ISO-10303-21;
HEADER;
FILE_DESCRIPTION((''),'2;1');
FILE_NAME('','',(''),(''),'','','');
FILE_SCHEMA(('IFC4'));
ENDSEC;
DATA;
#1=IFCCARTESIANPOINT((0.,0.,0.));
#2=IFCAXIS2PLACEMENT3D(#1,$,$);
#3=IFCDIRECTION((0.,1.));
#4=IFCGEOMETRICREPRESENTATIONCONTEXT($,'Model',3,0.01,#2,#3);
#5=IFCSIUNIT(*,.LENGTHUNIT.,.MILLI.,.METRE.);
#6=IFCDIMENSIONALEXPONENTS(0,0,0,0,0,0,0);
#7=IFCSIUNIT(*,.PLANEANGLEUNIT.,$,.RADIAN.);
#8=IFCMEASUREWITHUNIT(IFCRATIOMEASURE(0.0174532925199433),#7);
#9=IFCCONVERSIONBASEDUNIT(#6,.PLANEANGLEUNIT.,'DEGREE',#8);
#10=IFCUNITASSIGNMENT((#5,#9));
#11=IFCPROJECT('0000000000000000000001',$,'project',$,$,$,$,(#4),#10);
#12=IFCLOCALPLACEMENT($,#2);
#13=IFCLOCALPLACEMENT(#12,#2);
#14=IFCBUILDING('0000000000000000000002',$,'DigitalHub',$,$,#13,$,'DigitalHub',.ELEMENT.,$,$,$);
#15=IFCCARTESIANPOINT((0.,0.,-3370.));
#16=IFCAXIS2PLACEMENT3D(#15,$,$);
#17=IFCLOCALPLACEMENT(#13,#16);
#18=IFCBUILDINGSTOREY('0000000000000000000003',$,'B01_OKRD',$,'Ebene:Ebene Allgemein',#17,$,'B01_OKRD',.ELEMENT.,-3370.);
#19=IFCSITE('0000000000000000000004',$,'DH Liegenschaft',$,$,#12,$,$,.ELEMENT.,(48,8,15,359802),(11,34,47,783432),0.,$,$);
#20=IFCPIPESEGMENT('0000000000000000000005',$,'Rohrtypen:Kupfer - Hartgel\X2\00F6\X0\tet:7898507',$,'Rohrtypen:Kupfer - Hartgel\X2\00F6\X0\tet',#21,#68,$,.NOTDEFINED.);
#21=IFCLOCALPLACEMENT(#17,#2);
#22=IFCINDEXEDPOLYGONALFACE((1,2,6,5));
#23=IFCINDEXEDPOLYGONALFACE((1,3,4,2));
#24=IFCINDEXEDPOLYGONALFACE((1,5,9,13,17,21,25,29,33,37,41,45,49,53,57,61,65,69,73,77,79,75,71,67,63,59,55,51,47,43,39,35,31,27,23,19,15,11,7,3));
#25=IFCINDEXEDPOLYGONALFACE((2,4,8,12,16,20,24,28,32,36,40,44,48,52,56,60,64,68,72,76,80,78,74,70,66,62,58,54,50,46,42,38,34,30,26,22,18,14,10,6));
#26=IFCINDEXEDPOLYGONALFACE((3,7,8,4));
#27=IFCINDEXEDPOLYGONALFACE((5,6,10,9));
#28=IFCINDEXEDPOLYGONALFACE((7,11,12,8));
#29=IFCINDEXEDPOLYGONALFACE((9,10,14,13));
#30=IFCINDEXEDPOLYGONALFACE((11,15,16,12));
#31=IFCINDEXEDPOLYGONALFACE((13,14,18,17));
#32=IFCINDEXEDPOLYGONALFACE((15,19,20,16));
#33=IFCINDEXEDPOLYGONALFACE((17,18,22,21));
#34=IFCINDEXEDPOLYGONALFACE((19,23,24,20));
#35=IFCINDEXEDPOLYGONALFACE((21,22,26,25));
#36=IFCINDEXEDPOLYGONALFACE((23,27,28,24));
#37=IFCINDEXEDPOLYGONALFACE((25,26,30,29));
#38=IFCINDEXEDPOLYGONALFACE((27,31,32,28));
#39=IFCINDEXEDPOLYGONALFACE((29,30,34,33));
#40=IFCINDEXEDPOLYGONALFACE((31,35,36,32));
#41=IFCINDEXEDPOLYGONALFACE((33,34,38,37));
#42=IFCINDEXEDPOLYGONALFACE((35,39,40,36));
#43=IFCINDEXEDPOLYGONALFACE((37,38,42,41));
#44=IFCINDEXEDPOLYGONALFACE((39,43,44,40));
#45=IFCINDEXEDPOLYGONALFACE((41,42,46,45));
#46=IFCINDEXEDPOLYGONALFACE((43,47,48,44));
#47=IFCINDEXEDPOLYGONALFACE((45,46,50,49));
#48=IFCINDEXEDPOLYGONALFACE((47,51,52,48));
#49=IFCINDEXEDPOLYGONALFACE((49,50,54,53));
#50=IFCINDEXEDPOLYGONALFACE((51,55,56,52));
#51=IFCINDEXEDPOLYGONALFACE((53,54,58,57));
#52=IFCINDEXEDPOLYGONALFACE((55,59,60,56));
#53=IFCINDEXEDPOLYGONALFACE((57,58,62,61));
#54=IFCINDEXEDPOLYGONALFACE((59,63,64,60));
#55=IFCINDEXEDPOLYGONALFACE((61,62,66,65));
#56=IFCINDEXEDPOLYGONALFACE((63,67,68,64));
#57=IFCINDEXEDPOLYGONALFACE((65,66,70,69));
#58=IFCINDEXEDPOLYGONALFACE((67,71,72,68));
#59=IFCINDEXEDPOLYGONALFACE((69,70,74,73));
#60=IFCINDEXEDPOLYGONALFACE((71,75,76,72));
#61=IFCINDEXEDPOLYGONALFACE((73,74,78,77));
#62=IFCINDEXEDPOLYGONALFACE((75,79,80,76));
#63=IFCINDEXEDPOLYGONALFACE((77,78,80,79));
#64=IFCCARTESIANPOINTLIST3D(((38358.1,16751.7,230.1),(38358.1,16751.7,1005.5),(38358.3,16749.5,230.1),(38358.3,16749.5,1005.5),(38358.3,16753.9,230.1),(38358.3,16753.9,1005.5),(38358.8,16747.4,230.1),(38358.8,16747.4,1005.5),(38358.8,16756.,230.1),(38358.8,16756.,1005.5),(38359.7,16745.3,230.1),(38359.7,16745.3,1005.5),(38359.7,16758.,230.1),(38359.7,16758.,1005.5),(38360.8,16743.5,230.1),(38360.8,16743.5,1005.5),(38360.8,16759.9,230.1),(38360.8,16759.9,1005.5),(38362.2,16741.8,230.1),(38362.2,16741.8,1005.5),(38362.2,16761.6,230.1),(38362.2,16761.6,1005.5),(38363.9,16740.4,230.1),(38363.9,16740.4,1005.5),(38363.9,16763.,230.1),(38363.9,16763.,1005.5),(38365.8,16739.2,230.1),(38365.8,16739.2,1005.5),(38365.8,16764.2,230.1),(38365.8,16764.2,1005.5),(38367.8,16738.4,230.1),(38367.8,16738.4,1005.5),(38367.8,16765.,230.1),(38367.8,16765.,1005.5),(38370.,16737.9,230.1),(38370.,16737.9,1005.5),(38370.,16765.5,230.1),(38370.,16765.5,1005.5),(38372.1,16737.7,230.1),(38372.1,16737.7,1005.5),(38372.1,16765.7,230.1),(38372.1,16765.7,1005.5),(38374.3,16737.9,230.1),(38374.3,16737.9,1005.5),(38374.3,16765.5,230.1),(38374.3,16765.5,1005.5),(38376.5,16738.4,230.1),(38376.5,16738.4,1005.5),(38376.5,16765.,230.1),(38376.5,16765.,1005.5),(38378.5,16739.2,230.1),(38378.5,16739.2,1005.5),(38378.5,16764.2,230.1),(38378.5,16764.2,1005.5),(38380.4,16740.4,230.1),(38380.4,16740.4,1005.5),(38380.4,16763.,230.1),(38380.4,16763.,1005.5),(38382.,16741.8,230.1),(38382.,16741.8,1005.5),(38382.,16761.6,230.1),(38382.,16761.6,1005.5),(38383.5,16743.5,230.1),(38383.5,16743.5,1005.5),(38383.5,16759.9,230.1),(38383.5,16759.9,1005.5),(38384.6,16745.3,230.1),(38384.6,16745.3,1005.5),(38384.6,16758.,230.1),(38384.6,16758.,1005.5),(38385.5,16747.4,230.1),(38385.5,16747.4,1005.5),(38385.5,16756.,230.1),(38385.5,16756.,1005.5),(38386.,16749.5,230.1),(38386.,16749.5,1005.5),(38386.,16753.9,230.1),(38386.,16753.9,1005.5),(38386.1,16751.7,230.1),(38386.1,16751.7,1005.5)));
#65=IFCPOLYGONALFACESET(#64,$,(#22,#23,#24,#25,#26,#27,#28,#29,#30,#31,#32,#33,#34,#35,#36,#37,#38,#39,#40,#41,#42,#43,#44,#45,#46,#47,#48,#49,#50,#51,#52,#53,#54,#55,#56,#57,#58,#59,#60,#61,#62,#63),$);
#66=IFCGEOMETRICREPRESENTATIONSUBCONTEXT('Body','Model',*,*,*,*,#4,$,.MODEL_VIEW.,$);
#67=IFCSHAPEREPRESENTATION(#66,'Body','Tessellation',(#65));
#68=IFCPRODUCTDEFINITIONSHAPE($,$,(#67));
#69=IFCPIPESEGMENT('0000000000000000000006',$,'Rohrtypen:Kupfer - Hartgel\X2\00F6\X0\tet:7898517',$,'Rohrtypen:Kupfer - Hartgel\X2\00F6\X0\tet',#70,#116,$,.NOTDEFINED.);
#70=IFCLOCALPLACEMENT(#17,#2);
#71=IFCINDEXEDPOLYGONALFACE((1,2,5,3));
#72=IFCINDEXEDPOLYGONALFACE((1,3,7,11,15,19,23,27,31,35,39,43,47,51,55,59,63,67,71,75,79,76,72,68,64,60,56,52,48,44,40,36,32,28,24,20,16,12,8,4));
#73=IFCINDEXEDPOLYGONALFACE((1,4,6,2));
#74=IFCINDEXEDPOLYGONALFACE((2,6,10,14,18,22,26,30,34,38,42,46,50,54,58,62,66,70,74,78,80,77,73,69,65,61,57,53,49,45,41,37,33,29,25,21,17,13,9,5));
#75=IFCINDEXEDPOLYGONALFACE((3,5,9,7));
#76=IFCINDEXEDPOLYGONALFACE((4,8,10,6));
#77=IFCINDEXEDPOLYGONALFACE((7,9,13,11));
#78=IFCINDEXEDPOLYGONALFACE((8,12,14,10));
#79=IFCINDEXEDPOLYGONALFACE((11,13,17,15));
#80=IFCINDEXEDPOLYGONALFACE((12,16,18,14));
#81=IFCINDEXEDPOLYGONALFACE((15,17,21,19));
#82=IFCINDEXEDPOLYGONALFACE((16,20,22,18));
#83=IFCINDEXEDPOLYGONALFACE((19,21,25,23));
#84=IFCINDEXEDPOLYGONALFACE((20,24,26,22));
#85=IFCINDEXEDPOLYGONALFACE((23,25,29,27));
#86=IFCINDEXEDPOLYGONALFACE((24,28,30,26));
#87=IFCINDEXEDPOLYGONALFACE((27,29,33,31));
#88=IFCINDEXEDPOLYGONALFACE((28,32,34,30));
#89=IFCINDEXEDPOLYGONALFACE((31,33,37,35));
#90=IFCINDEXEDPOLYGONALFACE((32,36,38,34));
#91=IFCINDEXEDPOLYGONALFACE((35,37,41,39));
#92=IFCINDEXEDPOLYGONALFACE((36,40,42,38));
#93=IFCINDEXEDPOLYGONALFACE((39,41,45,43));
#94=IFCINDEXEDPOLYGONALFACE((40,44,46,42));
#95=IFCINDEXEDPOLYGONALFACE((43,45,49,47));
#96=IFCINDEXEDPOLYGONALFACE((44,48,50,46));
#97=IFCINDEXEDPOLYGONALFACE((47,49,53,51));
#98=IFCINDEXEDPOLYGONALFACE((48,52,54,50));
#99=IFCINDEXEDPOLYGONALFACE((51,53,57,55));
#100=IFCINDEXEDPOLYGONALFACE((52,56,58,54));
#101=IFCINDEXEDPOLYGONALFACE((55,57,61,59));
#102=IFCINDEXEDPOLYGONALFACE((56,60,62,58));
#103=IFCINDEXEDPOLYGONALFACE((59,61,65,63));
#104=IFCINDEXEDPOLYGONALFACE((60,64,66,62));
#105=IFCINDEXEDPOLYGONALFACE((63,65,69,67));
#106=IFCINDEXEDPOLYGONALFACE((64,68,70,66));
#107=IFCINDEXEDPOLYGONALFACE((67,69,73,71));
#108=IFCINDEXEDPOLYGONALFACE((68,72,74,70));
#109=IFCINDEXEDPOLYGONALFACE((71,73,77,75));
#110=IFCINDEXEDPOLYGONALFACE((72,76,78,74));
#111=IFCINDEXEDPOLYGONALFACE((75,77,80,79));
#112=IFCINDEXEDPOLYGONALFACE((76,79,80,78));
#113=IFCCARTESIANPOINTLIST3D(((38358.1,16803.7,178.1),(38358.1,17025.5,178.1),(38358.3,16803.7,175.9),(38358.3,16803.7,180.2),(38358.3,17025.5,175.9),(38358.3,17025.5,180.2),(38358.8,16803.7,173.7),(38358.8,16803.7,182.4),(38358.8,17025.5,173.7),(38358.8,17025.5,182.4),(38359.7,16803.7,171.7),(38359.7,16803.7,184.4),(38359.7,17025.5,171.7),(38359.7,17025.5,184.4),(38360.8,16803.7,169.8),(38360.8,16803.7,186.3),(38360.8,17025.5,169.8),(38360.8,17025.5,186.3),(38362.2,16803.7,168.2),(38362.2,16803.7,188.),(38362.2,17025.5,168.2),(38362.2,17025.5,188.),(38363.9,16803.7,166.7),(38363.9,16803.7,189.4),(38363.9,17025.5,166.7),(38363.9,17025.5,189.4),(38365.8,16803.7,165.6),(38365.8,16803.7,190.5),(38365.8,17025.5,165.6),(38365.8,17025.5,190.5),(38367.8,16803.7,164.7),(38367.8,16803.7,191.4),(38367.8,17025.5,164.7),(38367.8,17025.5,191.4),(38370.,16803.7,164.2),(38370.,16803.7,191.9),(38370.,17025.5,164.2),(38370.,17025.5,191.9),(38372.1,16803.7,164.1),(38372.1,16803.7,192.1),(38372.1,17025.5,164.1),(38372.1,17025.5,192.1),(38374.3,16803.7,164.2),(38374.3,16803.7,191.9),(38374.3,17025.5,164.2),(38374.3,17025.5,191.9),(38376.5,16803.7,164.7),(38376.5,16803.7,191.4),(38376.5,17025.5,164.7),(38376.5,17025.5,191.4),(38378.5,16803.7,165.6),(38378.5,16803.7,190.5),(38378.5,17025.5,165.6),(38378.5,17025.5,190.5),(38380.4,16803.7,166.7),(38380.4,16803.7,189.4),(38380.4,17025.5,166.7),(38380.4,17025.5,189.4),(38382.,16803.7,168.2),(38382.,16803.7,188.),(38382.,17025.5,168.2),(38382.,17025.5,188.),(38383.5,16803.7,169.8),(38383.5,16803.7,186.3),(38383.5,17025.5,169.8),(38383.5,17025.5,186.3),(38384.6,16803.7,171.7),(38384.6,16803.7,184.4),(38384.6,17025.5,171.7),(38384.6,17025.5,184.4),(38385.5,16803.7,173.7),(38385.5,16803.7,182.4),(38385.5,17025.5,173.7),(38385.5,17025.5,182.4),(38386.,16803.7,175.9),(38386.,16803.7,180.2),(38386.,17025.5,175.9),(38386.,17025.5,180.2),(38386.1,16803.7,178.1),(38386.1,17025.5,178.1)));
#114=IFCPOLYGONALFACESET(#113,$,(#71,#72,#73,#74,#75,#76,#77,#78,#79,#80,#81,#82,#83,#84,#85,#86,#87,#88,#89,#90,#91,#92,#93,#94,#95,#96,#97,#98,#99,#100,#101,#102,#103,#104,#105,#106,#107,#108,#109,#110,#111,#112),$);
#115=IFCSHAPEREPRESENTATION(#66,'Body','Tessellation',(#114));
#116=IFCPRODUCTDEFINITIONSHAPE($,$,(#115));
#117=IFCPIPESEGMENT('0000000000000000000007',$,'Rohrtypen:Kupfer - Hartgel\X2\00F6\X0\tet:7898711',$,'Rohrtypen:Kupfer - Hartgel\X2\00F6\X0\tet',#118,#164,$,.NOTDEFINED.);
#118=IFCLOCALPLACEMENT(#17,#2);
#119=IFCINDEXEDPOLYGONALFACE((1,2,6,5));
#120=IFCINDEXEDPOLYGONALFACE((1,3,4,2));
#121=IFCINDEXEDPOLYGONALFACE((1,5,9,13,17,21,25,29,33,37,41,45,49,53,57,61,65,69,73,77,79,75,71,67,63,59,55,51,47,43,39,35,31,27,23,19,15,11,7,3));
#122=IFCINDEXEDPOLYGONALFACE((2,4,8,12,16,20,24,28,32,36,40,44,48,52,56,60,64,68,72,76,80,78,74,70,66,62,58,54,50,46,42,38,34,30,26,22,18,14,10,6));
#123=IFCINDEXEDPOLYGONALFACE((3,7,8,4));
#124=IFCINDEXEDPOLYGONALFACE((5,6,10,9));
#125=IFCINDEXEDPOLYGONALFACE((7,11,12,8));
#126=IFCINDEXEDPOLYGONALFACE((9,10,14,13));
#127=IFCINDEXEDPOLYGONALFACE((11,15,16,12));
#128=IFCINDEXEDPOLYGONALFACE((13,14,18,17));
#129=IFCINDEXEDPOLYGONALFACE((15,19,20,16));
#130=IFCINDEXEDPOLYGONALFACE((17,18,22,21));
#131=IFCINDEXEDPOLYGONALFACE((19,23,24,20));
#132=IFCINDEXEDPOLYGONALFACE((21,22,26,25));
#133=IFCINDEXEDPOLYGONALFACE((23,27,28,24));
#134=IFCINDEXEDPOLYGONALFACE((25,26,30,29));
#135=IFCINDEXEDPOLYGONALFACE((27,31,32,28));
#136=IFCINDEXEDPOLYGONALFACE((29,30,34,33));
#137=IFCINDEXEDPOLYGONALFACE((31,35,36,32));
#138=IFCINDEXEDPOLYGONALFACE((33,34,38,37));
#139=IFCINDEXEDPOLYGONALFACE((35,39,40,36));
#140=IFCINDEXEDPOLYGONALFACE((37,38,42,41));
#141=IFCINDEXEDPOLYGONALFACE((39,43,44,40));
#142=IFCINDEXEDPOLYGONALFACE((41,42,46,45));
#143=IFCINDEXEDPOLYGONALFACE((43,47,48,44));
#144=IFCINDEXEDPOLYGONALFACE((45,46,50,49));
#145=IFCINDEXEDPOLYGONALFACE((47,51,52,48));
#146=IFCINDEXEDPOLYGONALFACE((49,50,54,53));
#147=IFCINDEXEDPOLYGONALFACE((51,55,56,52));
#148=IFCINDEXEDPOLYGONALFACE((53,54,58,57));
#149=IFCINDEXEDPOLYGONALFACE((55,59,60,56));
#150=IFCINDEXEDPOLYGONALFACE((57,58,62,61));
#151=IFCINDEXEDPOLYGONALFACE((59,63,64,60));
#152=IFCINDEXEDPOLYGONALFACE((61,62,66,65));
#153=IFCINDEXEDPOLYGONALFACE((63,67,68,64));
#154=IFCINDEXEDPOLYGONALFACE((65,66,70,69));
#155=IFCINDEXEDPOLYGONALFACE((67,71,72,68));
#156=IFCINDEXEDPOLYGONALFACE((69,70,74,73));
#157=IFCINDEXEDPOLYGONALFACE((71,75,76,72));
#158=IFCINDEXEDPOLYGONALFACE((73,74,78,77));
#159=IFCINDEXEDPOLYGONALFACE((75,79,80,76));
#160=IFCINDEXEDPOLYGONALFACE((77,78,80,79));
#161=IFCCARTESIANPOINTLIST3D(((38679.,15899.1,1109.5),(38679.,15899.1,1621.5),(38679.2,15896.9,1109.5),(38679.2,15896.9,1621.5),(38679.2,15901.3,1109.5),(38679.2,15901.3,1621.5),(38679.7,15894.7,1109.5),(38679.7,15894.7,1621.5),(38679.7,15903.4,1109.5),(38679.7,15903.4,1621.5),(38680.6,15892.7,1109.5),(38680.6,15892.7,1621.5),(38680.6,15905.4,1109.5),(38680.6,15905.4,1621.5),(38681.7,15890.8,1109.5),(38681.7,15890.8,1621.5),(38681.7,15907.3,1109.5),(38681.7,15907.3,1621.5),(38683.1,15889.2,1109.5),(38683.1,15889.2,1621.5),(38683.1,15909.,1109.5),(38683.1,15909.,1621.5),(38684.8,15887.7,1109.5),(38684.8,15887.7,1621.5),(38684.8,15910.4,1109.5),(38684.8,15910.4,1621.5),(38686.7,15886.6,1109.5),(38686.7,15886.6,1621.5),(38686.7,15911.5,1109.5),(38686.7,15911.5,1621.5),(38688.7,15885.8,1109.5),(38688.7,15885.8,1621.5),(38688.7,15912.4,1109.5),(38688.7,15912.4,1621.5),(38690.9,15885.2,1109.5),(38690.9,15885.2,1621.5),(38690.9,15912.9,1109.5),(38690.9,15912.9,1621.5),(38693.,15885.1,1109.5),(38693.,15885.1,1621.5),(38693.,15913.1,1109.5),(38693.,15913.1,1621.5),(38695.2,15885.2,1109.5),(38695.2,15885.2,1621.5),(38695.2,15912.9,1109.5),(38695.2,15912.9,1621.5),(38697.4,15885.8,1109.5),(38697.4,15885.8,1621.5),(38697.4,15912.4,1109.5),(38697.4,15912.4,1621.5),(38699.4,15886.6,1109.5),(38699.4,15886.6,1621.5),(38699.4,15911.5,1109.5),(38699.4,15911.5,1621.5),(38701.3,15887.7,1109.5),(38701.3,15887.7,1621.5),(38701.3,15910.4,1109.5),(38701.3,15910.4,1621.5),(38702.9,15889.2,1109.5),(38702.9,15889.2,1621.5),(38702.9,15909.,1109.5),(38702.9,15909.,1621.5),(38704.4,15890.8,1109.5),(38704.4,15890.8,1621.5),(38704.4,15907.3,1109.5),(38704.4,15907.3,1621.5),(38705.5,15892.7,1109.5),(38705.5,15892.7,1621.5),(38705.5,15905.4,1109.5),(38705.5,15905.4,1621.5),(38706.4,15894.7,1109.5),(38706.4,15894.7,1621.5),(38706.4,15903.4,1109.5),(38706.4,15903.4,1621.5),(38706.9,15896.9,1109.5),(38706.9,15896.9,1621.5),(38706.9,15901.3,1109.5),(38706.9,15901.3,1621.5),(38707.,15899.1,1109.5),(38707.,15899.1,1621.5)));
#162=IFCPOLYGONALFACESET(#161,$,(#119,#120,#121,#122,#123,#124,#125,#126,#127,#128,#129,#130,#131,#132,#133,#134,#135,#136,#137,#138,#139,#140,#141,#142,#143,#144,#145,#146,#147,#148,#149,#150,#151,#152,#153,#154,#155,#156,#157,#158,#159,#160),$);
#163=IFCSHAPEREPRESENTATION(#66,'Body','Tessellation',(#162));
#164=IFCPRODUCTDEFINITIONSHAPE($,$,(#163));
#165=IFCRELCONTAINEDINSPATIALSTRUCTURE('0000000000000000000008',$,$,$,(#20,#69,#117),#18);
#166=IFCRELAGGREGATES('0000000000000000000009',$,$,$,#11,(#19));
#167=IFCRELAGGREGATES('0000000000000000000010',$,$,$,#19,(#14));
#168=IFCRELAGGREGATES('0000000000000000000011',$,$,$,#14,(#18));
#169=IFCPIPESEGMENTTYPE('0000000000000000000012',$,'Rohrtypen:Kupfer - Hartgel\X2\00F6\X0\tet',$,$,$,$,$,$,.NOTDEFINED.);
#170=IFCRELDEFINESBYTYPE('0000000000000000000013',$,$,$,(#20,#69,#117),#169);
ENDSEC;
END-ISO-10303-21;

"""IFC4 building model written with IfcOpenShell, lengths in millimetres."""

from ifc_helpers import new_model, entity, si_unit, converted_unit, direction, frame, origin, place, context, subcontext, project, spatial, indexed_curve, outline, extrude, type_object, element, save


model = new_model("IFC4")

# Units and contexts
model_context = context("Model", 3, precision=0.01, world=origin(), true_north=direction((0.0, 1.0)))
body_context = subcontext(model_context, "Body", "Model", "MODEL_VIEW")
ifc_project = project(units=[si_unit("LENGTHUNIT", "METRE", prefix="MILLI"), converted_unit("PLANEANGLEUNIT", "DEGREE", entity("IfcRatioMeasure", 0.0174532925199433), si_unit("PLANEANGLEUNIT", "RADIAN"), dimensions=[0, 0, 0, 0, 0, 0, 0])], contexts=[model_context])

# Site, building, storey
site_placement = place(None, origin())
site = spatial("IfcSite", under=ifc_project, at=site_placement, Name="DH Liegenschaft", CompositionType="ELEMENT", RefLatitude=(48, 8, 15, 359802), RefLongitude=(11, 34, 47, 783432), RefElevation=0.0)
building_placement = place(site_placement, origin())
building = spatial("IfcBuilding", under=site, at=building_placement, Name="DigitalHub", LongName="DigitalHub", CompositionType="ELEMENT")
storey_placement = place(building_placement, frame((0.0, 0.0, -3370.0)))
storey = spatial("IfcBuildingStorey", under=building, at=storey_placement, Name="B01_OKRD", ObjectType="Ebene:Ebene Allgemein", LongName="B01_OKRD", CompositionType="ELEMENT", Elevation=-3370.0)

# Pipe segments
pipe_segment_type = type_object("IfcPipeSegmentType", Name="Rohrtypen:Kupfer - Hartgelötet", PredefinedType="NOTDEFINED")
pipe_segment_1_placement = place(storey_placement, frame((38356.6, 16736.1, 230.1)))
element("IfcPipeSegment", 1, at=pipe_segment_1_placement, inside=storey, type_object=pipe_segment_type, Name="Rohrtypen:Kupfer - Hartgelötet:7898507", ObjectType="Rohrtypen:Kupfer - Hartgelötet", PredefinedType="NOTDEFINED", context=body_context, shape_type="SweptSolid", body=[
    extrude(outline(indexed_curve([(14.0, 0.0), (13.8, 2.2), (13.3, 4.3), (12.5, 6.4), (11.3, 8.2), (9.9, 9.9), (8.2, 11.3), (6.4, 12.5), (4.3, 13.3), (2.2, 13.8), (0.0, 14.0), (-2.2, 13.8), (-4.3, 13.3), (-6.4, 12.5), (-8.2, 11.3), (-9.9, 9.9), (-11.3, 8.2), (-12.5, 6.4), (-13.3, 4.3), (-13.8, 2.2), (-14.0, 0.0), (-13.8, -2.2), (-13.3, -4.3), (-12.5, -6.4), (-11.3, -8.2), (-9.9, -9.9), (-8.2, -11.3), (-6.4, -12.5), (-4.3, -13.3), (-2.2, -13.8), (0.0, -14.0), (2.2, -13.8), (4.3, -13.3), (6.4, -12.5), (8.2, -11.3), (9.9, -9.9), (11.3, -8.2), (12.5, -6.4), (13.3, -4.3), (13.8, -2.2), (14.0, 0.0)], self_intersect=False)), frame((15.6, 15.6, 0.0)), (0.0, 0.0, 1.0), 775.4),
])
pipe_segment_2_placement = place(storey_placement, frame((38356.6, 16803.7, 162.5)))
element("IfcPipeSegment", 2, at=pipe_segment_2_placement, inside=storey, type_object=pipe_segment_type, Name="Rohrtypen:Kupfer - Hartgelötet:7898517", ObjectType="Rohrtypen:Kupfer - Hartgelötet", PredefinedType="NOTDEFINED", context=body_context, shape_type="SweptSolid", body=[
    extrude(outline(indexed_curve([(14.0, 0.0), (13.8, 2.2), (13.3, 4.3), (12.5, 6.4), (11.3, 8.2), (9.9, 9.9), (8.2, 11.3), (6.4, 12.5), (4.3, 13.3), (2.2, 13.8), (0.0, 14.0), (-2.2, 13.8), (-4.3, 13.3), (-6.4, 12.5), (-8.2, 11.3), (-9.9, 9.9), (-11.3, 8.2), (-12.5, 6.4), (-13.3, 4.3), (-13.8, 2.2), (-14.0, 0.0), (-13.8, -2.2), (-13.3, -4.3), (-12.5, -6.4), (-11.3, -8.2), (-9.9, -9.9), (-8.2, -11.3), (-6.4, -12.5), (-4.3, -13.3), (-2.2, -13.8), (0.0, -14.0), (2.2, -13.8), (4.3, -13.3), (6.4, -12.5), (8.2, -11.3), (9.9, -9.9), (11.3, -8.2), (12.5, -6.4), (13.3, -4.3), (13.8, -2.2), (14.0, 0.0)], self_intersect=False)), frame((15.6, 0.0, 15.6), z_axis=(0.0, 1.0, 0.0), x_axis=(1.0, 0.0, 0.0)), (0.0, 0.0, 1.0), 221.8),
])
pipe_segment_3_placement = place(storey_placement, frame((38677.4, 15883.5, 1109.5)))
element("IfcPipeSegment", 3, at=pipe_segment_3_placement, inside=storey, type_object=pipe_segment_type, Name="Rohrtypen:Kupfer - Hartgelötet:7898711", ObjectType="Rohrtypen:Kupfer - Hartgelötet", PredefinedType="NOTDEFINED", context=body_context, shape_type="SweptSolid", body=[
    extrude(outline(indexed_curve([(14.0, 0.0), (13.8, 2.2), (13.3, 4.3), (12.5, 6.4), (11.3, 8.2), (9.9, 9.9), (8.2, 11.3), (6.4, 12.5), (4.3, 13.3), (2.2, 13.8), (0.0, 14.0), (-2.2, 13.8), (-4.3, 13.3), (-6.4, 12.5), (-8.2, 11.3), (-9.9, 9.9), (-11.3, 8.2), (-12.5, 6.4), (-13.3, 4.3), (-13.8, 2.2), (-14.0, 0.0), (-13.8, -2.2), (-13.3, -4.3), (-12.5, -6.4), (-11.3, -8.2), (-9.9, -9.9), (-8.2, -11.3), (-6.4, -12.5), (-4.3, -13.3), (-2.2, -13.8), (0.0, -14.0), (2.2, -13.8), (4.3, -13.3), (6.4, -12.5), (8.2, -11.3), (9.9, -9.9), (11.3, -8.2), (12.5, -6.4), (13.3, -4.3), (13.8, -2.2), (14.0, 0.0)], self_intersect=False)), frame((15.6, 15.6, 0.0)), (0.0, 0.0, 1.0), 512.0),
])

save(model, "model.ifc")
